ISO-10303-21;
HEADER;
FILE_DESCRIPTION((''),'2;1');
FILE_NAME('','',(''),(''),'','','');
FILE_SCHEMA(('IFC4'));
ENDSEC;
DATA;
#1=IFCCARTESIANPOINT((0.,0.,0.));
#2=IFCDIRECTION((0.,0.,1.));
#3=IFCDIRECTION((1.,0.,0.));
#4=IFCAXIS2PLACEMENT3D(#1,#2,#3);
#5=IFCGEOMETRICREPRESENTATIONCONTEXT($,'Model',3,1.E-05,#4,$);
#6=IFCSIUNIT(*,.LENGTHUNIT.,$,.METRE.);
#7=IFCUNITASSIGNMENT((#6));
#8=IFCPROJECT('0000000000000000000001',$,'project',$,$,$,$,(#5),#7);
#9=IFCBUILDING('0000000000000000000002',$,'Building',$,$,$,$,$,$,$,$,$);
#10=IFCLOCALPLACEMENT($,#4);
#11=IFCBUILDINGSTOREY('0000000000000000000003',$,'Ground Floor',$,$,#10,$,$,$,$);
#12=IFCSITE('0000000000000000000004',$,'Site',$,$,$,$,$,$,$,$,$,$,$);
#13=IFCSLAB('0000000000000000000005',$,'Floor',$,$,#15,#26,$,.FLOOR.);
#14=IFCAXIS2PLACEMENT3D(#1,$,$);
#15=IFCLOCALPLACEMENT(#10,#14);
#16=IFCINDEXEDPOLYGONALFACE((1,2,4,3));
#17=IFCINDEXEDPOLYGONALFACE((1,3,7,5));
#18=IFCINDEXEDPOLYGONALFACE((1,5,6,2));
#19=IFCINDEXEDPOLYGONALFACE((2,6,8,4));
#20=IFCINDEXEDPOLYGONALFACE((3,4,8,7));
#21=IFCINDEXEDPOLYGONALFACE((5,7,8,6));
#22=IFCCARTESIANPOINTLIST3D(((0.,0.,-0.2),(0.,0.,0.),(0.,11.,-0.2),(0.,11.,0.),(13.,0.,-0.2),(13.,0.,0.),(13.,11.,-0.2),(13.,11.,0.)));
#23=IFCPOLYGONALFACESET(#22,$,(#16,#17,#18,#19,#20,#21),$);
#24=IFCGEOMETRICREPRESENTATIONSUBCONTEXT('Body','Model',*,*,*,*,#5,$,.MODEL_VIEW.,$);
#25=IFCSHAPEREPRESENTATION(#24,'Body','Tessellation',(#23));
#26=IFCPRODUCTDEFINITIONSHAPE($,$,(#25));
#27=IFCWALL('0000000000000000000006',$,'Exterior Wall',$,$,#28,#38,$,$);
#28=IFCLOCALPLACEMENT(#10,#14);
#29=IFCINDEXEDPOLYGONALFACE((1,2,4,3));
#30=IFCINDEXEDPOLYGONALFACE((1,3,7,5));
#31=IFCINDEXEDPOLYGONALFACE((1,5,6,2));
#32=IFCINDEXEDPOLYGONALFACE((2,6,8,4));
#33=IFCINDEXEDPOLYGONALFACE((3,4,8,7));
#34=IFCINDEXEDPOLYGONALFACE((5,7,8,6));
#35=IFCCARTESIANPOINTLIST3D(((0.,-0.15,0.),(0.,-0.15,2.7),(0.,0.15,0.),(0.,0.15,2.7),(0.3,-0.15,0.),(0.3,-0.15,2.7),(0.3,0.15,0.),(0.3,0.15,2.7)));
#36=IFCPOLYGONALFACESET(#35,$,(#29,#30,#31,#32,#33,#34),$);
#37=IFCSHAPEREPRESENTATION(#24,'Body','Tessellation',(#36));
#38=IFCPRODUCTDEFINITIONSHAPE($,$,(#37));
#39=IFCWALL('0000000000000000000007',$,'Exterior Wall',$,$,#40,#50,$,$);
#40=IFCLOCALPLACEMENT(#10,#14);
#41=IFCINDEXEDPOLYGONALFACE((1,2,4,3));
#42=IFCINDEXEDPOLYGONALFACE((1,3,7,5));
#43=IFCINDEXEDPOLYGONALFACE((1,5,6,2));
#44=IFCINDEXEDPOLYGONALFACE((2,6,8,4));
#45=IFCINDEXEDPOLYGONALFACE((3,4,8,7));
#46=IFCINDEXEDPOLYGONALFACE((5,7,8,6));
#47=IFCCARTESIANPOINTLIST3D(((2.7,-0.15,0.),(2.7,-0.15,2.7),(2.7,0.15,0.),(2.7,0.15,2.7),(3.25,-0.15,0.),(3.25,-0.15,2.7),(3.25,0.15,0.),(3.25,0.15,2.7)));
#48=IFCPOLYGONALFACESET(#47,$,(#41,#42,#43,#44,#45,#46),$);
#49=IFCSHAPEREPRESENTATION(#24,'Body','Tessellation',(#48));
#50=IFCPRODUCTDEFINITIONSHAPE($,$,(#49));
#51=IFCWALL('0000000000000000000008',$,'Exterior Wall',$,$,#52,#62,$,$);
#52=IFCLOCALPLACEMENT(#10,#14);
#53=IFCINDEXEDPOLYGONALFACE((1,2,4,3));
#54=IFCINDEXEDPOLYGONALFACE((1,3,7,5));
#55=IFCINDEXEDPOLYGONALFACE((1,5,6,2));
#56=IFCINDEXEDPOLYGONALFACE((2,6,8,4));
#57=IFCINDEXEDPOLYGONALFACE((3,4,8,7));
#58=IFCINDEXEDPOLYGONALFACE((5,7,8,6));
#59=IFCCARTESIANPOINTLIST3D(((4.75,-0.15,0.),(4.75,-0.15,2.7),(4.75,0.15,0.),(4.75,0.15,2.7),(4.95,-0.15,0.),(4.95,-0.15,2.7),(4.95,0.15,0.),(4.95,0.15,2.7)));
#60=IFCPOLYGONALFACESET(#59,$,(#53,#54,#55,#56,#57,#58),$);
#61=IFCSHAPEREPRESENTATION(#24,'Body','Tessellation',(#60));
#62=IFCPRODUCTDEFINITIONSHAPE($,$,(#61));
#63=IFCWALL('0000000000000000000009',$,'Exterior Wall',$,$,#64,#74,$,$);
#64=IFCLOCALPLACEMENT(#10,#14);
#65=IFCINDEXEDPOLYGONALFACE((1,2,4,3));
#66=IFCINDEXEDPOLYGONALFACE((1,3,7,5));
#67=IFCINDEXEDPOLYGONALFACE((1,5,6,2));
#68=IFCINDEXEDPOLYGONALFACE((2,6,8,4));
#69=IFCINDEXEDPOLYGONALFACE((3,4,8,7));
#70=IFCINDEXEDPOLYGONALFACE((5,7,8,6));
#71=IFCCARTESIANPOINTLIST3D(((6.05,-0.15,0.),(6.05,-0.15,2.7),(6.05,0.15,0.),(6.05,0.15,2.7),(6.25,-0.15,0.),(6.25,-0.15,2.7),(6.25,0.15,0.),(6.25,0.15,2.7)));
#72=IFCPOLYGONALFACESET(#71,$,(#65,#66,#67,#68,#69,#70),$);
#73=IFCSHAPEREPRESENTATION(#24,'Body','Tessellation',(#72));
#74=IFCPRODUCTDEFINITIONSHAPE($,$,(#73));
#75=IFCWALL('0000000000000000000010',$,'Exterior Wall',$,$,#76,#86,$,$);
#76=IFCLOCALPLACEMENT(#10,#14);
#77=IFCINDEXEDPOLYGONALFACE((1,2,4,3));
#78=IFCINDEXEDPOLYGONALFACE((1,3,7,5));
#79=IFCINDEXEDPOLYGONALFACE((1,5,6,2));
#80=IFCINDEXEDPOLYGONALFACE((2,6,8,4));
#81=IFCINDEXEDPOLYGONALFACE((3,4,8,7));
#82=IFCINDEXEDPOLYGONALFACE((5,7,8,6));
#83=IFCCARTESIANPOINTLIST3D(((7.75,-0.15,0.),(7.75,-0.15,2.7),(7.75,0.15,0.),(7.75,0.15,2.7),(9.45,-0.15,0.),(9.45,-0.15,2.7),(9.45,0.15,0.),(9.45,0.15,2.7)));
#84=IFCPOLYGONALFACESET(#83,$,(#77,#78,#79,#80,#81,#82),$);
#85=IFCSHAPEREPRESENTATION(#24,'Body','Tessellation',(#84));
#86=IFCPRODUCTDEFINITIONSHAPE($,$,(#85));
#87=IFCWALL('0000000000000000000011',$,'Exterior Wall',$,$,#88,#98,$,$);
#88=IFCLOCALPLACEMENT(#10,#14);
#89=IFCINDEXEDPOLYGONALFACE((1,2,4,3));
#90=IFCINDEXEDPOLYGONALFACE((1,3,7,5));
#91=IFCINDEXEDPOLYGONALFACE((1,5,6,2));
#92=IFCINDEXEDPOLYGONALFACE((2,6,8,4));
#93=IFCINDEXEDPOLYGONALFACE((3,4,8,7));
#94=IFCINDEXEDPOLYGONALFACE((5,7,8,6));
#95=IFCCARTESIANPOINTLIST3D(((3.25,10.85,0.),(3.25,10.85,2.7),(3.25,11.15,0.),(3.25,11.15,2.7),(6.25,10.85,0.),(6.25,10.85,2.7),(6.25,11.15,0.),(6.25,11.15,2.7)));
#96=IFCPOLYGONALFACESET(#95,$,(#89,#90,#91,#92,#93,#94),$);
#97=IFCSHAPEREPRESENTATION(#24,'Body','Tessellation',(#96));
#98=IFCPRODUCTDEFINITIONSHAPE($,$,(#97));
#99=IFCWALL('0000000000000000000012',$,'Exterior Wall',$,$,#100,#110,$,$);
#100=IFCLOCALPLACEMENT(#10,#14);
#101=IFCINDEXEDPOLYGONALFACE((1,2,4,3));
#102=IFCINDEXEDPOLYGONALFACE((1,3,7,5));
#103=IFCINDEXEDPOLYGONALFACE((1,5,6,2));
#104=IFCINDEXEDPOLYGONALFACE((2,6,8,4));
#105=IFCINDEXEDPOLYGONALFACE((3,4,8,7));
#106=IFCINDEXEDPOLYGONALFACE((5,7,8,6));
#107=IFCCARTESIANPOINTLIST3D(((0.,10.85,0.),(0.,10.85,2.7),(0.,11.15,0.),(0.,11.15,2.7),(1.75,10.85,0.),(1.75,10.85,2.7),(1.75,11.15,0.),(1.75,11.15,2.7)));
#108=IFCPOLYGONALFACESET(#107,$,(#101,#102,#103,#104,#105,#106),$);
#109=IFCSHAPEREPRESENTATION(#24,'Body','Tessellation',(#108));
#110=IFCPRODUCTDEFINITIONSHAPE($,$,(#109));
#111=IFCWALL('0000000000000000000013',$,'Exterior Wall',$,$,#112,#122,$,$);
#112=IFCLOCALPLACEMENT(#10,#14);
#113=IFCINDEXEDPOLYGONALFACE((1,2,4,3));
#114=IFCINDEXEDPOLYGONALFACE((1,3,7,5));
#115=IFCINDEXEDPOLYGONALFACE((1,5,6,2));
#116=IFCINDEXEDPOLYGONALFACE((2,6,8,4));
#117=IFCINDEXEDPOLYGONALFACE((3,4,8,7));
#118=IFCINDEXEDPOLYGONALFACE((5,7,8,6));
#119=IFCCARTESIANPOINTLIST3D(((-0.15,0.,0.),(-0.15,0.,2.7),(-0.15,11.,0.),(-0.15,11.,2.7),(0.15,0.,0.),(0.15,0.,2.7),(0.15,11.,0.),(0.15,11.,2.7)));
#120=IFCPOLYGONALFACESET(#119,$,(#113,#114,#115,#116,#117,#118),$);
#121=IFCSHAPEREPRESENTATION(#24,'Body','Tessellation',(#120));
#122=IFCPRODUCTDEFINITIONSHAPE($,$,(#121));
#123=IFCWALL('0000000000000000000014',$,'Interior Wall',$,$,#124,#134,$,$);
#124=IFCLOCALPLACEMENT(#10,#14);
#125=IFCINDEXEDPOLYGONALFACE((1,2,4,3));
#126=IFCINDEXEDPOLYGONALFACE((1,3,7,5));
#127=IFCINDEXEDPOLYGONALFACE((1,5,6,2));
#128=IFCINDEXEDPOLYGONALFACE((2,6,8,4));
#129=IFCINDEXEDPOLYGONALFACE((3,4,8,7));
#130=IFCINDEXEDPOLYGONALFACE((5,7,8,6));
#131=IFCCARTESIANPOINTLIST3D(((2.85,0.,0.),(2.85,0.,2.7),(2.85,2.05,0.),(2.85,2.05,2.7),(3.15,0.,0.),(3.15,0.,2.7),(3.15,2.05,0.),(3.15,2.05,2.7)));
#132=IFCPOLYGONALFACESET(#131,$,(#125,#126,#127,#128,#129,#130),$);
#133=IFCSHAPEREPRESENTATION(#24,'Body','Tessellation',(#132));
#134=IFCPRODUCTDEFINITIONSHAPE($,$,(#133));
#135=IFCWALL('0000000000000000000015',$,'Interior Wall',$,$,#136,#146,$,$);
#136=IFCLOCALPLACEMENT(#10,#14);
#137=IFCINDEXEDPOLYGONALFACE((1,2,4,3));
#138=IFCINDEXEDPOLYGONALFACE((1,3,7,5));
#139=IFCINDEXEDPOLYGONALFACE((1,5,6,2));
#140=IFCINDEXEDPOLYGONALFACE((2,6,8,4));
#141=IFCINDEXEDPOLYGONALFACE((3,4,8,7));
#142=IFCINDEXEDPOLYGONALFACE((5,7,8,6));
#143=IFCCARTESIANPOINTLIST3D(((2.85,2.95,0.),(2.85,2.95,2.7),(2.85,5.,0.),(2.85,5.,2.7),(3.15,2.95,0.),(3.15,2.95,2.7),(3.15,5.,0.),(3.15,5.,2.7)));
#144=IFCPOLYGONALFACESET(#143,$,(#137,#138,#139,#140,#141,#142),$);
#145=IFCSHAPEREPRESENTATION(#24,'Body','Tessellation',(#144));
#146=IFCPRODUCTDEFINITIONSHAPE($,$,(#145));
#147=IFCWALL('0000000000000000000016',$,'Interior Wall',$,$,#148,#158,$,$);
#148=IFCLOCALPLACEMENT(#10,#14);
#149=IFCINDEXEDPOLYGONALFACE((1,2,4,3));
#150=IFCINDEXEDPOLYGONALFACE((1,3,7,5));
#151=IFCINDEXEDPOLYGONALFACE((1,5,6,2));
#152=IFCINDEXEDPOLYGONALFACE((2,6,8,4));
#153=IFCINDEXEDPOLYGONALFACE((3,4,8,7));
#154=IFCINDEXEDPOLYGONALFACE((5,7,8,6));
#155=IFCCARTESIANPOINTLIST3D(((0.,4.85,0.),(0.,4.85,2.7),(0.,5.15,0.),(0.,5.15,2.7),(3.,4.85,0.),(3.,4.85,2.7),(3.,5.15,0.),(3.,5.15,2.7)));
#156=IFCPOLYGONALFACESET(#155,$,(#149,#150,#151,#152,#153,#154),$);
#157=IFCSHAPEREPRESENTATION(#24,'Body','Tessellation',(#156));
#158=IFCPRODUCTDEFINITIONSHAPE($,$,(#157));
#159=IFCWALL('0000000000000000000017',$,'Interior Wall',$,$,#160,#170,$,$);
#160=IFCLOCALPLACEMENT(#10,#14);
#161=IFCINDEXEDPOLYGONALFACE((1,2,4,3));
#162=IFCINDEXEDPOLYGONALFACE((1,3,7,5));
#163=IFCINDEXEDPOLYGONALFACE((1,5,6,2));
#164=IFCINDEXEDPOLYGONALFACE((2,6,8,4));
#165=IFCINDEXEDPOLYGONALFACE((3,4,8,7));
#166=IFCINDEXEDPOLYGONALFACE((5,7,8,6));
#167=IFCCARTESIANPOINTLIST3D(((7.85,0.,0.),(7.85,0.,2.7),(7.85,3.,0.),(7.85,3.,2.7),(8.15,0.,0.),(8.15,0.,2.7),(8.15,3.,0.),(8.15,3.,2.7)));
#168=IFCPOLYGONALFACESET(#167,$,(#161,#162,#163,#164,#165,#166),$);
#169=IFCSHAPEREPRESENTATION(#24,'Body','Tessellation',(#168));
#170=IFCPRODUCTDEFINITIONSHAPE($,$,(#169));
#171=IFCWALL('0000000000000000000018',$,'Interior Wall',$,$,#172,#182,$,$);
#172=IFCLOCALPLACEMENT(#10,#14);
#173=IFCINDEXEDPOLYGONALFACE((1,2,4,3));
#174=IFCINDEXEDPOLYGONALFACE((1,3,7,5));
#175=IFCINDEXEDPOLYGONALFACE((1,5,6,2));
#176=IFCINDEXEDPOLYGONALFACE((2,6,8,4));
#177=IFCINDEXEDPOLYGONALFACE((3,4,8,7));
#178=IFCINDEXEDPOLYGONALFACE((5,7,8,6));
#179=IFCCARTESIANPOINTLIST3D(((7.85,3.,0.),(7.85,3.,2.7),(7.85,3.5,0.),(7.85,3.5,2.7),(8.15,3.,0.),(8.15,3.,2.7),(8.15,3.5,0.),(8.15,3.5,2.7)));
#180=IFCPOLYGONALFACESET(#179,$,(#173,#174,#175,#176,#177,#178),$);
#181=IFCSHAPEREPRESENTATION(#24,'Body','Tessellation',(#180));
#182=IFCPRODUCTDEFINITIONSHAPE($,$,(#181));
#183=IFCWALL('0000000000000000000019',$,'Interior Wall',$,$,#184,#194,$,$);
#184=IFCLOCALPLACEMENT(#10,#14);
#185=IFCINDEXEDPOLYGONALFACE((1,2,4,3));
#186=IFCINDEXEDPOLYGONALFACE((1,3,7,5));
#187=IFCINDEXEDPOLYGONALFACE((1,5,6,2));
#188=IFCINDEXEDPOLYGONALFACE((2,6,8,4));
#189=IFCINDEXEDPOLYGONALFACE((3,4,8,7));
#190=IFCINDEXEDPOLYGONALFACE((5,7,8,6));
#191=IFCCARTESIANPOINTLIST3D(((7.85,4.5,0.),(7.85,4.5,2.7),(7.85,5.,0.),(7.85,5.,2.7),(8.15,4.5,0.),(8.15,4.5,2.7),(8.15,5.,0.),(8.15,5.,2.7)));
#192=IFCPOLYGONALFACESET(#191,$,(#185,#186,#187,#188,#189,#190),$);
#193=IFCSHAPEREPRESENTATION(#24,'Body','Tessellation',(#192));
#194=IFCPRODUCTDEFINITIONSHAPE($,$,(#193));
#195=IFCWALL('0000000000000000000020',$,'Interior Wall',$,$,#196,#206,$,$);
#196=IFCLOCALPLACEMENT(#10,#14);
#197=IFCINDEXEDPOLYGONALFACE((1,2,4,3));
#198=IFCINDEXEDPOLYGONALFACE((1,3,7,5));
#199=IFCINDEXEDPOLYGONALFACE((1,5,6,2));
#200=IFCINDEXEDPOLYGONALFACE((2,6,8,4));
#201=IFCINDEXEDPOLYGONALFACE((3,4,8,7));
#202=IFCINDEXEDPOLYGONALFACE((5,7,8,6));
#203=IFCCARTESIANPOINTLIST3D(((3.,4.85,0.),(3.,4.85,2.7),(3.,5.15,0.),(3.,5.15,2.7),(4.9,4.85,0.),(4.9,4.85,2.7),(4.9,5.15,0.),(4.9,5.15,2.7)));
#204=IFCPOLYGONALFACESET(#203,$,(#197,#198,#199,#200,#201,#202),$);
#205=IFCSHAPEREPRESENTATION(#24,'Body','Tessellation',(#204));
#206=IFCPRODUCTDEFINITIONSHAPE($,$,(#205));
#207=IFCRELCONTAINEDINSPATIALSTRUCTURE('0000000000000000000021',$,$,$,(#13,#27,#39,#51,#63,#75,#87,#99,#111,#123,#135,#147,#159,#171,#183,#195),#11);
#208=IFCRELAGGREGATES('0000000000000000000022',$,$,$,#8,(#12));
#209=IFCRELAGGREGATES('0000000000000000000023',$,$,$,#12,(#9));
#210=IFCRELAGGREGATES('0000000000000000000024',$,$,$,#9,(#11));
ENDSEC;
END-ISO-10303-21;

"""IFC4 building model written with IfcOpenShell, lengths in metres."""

from ifc_helpers import new_model, si_unit, frame, origin_with_axes, place, context, subcontext, project, spatial, indexed_curve, outline, extrude, element, save


model = new_model("IFC4")

# Units and contexts
model_context = context("Model", 3, precision=1e-05, world=origin_with_axes())
body_context = subcontext(model_context, "Body", "Model", "MODEL_VIEW")
ifc_project = project(units=[si_unit("LENGTHUNIT", "METRE")], contexts=[model_context])

# Site, building, storey
site = spatial("IfcSite", under=ifc_project, Name="Site")
building = spatial("IfcBuilding", under=site, Name="Building")
storey_placement = place(None, origin_with_axes())
storey = spatial("IfcBuildingStorey", under=building, at=storey_placement, Name="Ground Floor")

# Slab
slab_placement = place(storey_placement, frame((0.0, 0.0, -0.2), z_axis=(0.0, 0.0, 1.0), x_axis=(1.0, 0.0, 0.0)))
element("IfcSlab", 1, at=slab_placement, inside=storey, Name="Floor", PredefinedType="FLOOR", context=body_context, shape_type="SweptSolid", body=[
    extrude(outline(indexed_curve([(0.0, 0.0), (13.0, 0.0), (13.0, 11.0), (0.0, 11.0)])), None, (0.0, 0.0, 1.0), 0.2),
])

# Walls
wall_1_placement = place(storey_placement, origin_with_axes())
element("IfcWall", 2, at=wall_1_placement, inside=storey, Name="Exterior Wall", context=body_context, shape_type="SweptSolid", body=[
    extrude(outline(indexed_curve([(0.0, 0.0), (0.0, 0.3), (0.3, 0.3), (0.3, 0.0), (0.0, 0.0)], self_intersect=False)), frame((0.0, -0.15, 0.0), z_axis=(0.0, 0.0, 1.0), x_axis=(1.0, 0.0, 0.0)), (0.0, 0.0, 1.0), 2.7),
])
wall_2_placement = place(storey_placement, frame((2.7, 0.0, 0.0), z_axis=(0.0, 0.0, 1.0), x_axis=(1.0, 0.0, 0.0)))
element("IfcWall", 3, at=wall_2_placement, inside=storey, Name="Exterior Wall", context=body_context, shape_type="SweptSolid", body=[
    extrude(outline(indexed_curve([(0.0, 0.0), (0.0, 0.3), (0.55, 0.3), (0.55, 0.0), (0.0, 0.0)], self_intersect=False)), frame((0.0, -0.15, 0.0), z_axis=(0.0, 0.0, 1.0), x_axis=(1.0, 0.0, 0.0)), (0.0, 0.0, 1.0), 2.7),
])
for number, where, z_axis, x_axis, name in (
    (4, (4.75, 0.0, 0.0), (0.0, 0.0, 1.0), (1.0, 0.0, 0.0), "Exterior Wall"),
    (5, (6.05, 0.0, 0.0), (0.0, 0.0, 1.0), (1.0, 0.0, 0.0), "Exterior Wall"),
):
    element("IfcWall", number, at=place(storey_placement, frame(where, z_axis=z_axis, x_axis=x_axis)), inside=storey, Name=name, context=body_context, shape_type="SweptSolid", body=[
        extrude(outline(indexed_curve([(0.0, 0.0), (0.0, 0.3), (0.2, 0.3), (0.2, 0.0), (0.0, 0.0)], self_intersect=False)), frame((0.0, -0.15, 0.0), z_axis=(0.0, 0.0, 1.0), x_axis=(1.0, 0.0, 0.0)), (0.0, 0.0, 1.0), 2.7),
    ])
wall_3_placement = place(storey_placement, frame((7.75, 0.0, 0.0), z_axis=(0.0, 0.0, 1.0), x_axis=(1.0, 0.0, 0.0)))
element("IfcWall", 6, at=wall_3_placement, inside=storey, Name="Exterior Wall", context=body_context, shape_type="SweptSolid", body=[
    extrude(outline(indexed_curve([(0.0, 0.0), (0.0, 0.3), (1.7, 0.3), (1.7, 0.0), (0.0, 0.0)], self_intersect=False)), frame((0.0, -0.15, 0.0), z_axis=(0.0, 0.0, 1.0), x_axis=(1.0, 0.0, 0.0)), (0.0, 0.0, 1.0), 2.7),
])
wall_4_placement = place(storey_placement, frame((6.25, 11.0, 0.0), z_axis=(0.0, 0.0, 1.0), x_axis=(-1.0, 0.0, 0.0)))
element("IfcWall", 7, at=wall_4_placement, inside=storey, Name="Exterior Wall", context=body_context, shape_type="SweptSolid", body=[
    extrude(outline(indexed_curve([(0.0, 0.0), (0.0, 0.3), (3.0, 0.3), (3.0, 0.0), (0.0, 0.0)], self_intersect=False)), frame((0.0, -0.15, 0.0), z_axis=(0.0, 0.0, 1.0), x_axis=(1.0, 0.0, 0.0)), (0.0, 0.0, 1.0), 2.7),
])
wall_5_placement = place(storey_placement, frame((1.75, 11.0, 0.0), z_axis=(0.0, 0.0, 1.0), x_axis=(-1.0, 0.0, 0.0)))
element("IfcWall", 8, at=wall_5_placement, inside=storey, Name="Exterior Wall", context=body_context, shape_type="SweptSolid", body=[
    extrude(outline(indexed_curve([(0.0, 0.0), (0.0, 0.3), (1.75, 0.3), (1.75, 0.0), (0.0, 0.0)], self_intersect=False)), frame((0.0, -0.15, 0.0), z_axis=(0.0, 0.0, 1.0), x_axis=(1.0, 0.0, 0.0)), (0.0, 0.0, 1.0), 2.7),
])
wall_6_placement = place(storey_placement, frame((0.0, 11.0, 0.0), z_axis=(0.0, 0.0, 1.0), x_axis=(0.0, -1.0, 0.0)))
element("IfcWall", 9, at=wall_6_placement, inside=storey, Name="Exterior Wall", context=body_context, shape_type="SweptSolid", body=[
    extrude(outline(indexed_curve([(0.0, 0.0), (0.0, 0.3), (11.0, 0.3), (11.0, 0.0), (0.0, 0.0)], self_intersect=False)), frame((0.0, -0.15, 0.0), z_axis=(0.0, 0.0, 1.0), x_axis=(1.0, 0.0, 0.0)), (0.0, 0.0, 1.0), 2.7),
])
for number, where, z_axis, x_axis, name in (
    (10, (3.0, 0.0, 0.0), (0.0, 0.0, 1.0), (0.0, 1.0, 0.0), "Interior Wall"),
    (11, (3.0, 2.95, 0.0), (0.0, 0.0, 1.0), (0.0, 1.0, 0.0), "Interior Wall"),
):
    element("IfcWall", number, at=place(storey_placement, frame(where, z_axis=z_axis, x_axis=x_axis)), inside=storey, Name=name, context=body_context, shape_type="SweptSolid", body=[
        extrude(outline(indexed_curve([(0.0, 0.0), (0.0, 0.3), (2.05, 0.3), (2.05, 0.0), (0.0, 0.0)], self_intersect=False)), frame((0.0, -0.15, 0.0), z_axis=(0.0, 0.0, 1.0), x_axis=(1.0, 0.0, 0.0)), (0.0, 0.0, 1.0), 2.7),
    ])
for number, where, z_axis, x_axis, name in (
    (12, (3.0, 5.0, 0.0), (0.0, 0.0, 1.0), (-1.0, 0.0, 0.0), "Interior Wall"),
    (13, (8.0, 0.0, 0.0), (0.0, 0.0, 1.0), (0.0, 1.0, 0.0), "Interior Wall"),
):
    element("IfcWall", number, at=place(storey_placement, frame(where, z_axis=z_axis, x_axis=x_axis)), inside=storey, Name=name, context=body_context, shape_type="SweptSolid", body=[
        extrude(outline(indexed_curve([(0.0, 0.0), (0.0, 0.3), (3.0, 0.3), (3.0, 0.0), (0.0, 0.0)], self_intersect=False)), frame((0.0, -0.15, 0.0), z_axis=(0.0, 0.0, 1.0), x_axis=(1.0, 0.0, 0.0)), (0.0, 0.0, 1.0), 2.7),
    ])
for number, where, z_axis, x_axis, name in (
    (14, (8.0, 3.0, 0.0), (0.0, 0.0, 1.0), (0.0, 1.0, 0.0), "Interior Wall"),
    (15, (8.0, 4.5, 0.0), (0.0, 0.0, 1.0), (0.0, 1.0, 0.0), "Interior Wall"),
):
    element("IfcWall", number, at=place(storey_placement, frame(where, z_axis=z_axis, x_axis=x_axis)), inside=storey, Name=name, context=body_context, shape_type="SweptSolid", body=[
        extrude(outline(indexed_curve([(0.0, 0.0), (0.0, 0.3), (0.5, 0.3), (0.5, 0.0), (0.0, 0.0)], self_intersect=False)), frame((0.0, -0.15, 0.0), z_axis=(0.0, 0.0, 1.0), x_axis=(1.0, 0.0, 0.0)), (0.0, 0.0, 1.0), 2.7),
    ])
wall_7_placement = place(storey_placement, frame((4.9, 5.0, 0.0), z_axis=(0.0, 0.0, 1.0), x_axis=(-1.0, 0.0, 0.0)))
element("IfcWall", 16, at=wall_7_placement, inside=storey, Name="Interior Wall", context=body_context, shape_type="SweptSolid", body=[
    extrude(outline(indexed_curve([(0.0, 0.0), (0.0, 0.3), (1.9, 0.3), (1.9, 0.0), (0.0, 0.0)], self_intersect=False)), frame((0.0, -0.15, 0.0), z_axis=(0.0, 0.0, 1.0), x_axis=(1.0, 0.0, 0.0)), (0.0, 0.0, 1.0), 2.7),
])

save(model, "model.ifc")
